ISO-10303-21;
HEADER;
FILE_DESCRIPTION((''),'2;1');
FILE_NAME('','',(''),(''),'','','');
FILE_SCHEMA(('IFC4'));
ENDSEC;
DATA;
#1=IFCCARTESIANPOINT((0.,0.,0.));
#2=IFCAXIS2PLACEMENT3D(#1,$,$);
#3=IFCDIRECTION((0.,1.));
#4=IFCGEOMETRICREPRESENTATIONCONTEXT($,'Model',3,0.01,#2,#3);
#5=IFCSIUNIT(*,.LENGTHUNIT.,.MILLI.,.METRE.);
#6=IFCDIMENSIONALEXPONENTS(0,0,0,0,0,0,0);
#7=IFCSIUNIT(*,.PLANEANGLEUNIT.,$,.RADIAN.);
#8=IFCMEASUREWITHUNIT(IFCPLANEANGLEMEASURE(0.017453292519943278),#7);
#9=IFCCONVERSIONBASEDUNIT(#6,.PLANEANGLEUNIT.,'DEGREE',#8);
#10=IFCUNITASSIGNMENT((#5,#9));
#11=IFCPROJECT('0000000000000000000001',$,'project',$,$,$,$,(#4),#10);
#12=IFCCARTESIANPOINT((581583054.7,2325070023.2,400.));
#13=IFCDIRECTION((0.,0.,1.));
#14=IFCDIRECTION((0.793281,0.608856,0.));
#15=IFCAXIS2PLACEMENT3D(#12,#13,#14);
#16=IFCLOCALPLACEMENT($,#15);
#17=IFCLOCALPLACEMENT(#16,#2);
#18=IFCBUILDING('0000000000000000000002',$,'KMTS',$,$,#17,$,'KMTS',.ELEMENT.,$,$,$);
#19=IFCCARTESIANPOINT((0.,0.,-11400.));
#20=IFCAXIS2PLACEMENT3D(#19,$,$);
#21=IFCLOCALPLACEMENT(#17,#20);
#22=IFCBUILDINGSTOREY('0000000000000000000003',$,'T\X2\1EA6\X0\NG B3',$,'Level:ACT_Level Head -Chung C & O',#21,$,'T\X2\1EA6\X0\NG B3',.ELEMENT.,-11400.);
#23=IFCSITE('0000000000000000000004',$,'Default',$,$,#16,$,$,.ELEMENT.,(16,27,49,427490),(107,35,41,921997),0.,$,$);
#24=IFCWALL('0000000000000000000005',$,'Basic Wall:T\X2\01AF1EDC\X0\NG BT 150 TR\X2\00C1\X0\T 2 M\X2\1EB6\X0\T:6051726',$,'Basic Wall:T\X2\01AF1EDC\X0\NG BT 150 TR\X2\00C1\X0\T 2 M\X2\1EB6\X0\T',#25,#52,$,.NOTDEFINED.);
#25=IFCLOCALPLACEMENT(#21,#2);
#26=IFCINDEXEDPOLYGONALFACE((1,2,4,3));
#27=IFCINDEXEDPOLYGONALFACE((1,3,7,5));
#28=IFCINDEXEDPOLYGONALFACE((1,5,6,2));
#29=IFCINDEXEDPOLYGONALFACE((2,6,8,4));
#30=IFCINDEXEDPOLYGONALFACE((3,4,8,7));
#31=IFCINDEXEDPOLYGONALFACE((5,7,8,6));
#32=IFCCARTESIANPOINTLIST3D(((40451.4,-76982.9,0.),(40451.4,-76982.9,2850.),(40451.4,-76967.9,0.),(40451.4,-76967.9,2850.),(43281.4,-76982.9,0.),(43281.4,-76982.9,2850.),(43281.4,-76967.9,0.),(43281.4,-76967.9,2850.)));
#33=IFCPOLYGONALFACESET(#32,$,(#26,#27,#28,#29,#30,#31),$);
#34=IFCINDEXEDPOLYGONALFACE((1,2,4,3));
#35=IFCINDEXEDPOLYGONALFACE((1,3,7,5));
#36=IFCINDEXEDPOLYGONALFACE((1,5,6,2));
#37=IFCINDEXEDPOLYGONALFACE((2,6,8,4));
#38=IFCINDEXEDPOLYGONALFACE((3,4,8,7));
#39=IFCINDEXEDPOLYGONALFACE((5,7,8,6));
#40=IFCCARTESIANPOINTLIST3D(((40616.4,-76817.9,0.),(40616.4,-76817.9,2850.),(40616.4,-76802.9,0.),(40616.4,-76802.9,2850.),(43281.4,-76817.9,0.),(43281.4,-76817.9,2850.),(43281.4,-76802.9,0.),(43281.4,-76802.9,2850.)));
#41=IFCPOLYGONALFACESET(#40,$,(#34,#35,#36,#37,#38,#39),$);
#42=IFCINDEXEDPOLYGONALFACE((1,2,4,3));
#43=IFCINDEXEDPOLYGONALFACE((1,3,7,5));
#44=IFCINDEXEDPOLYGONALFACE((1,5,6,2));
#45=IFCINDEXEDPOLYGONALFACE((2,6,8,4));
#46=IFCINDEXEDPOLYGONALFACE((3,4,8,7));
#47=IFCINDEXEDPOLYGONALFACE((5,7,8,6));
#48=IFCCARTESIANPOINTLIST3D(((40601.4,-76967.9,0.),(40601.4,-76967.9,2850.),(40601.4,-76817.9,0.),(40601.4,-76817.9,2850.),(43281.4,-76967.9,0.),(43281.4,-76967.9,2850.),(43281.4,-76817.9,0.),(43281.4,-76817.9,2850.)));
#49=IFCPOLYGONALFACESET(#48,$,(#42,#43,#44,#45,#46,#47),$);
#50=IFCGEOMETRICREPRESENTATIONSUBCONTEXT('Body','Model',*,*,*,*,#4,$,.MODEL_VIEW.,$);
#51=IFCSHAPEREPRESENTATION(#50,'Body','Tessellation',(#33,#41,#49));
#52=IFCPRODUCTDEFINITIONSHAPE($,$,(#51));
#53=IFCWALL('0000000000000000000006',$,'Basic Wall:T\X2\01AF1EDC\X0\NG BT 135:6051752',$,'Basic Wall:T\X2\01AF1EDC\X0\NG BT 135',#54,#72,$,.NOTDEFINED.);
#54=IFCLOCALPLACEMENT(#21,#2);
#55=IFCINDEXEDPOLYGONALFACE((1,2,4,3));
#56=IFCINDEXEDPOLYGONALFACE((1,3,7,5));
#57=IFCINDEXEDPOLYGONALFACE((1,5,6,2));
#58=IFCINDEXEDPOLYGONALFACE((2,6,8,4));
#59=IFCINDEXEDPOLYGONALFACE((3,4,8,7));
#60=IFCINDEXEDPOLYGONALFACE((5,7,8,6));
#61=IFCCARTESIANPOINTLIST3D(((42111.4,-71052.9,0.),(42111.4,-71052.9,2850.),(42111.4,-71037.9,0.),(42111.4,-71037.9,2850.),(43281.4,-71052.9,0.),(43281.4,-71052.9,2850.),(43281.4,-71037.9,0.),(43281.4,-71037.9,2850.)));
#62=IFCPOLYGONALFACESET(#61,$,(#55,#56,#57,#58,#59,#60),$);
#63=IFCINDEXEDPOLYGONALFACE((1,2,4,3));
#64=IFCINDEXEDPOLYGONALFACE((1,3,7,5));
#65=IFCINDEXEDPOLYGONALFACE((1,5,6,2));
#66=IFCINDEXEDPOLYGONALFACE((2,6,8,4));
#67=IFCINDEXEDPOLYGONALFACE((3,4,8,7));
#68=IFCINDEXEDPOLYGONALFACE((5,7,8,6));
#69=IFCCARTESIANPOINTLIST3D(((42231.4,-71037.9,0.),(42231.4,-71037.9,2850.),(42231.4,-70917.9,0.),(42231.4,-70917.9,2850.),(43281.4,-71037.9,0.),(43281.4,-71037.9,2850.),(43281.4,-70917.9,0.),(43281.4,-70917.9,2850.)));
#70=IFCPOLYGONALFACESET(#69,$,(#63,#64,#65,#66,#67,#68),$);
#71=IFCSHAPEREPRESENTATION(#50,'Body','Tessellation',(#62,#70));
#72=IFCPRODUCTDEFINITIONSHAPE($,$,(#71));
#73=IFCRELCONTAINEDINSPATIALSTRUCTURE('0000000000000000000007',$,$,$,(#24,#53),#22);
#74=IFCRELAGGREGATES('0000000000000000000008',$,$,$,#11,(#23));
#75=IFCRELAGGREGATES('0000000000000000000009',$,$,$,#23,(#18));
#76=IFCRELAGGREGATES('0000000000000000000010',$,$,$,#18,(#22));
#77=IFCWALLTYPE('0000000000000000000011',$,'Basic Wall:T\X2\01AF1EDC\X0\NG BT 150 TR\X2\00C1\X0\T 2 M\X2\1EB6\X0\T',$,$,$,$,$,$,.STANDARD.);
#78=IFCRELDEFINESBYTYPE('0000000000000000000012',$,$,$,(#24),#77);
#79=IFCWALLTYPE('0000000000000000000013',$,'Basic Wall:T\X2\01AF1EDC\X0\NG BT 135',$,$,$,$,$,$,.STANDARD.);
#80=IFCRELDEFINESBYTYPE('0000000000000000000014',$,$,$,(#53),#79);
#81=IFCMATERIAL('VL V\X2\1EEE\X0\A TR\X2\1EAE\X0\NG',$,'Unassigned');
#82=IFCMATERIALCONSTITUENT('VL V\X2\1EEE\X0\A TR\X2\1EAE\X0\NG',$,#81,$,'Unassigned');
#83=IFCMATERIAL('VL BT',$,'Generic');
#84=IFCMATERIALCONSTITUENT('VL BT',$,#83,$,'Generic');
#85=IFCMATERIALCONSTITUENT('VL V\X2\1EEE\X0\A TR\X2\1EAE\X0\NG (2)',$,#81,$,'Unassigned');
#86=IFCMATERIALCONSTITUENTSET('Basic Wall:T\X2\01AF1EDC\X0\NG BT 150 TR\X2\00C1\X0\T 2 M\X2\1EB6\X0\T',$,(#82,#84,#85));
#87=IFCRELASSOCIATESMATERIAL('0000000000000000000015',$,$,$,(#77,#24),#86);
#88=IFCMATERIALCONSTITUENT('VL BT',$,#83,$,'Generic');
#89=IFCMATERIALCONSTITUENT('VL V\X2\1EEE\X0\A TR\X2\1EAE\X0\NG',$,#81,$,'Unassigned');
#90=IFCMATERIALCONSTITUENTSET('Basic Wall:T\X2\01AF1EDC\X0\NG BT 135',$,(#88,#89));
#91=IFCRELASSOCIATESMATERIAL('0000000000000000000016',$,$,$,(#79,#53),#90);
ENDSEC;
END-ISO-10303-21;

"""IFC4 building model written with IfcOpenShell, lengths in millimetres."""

from ifc_helpers import new_model, entity, si_unit, converted_unit, direction, frame, origin, place, context, subcontext, project, spatial, indexed_curve, outline, extrude, material, constituent, constituent_set, type_object, element, save


model = new_model("IFC4")

# Units and contexts
model_context = context("Model", 3, precision=0.01, world=origin(), true_north=direction((0.0, 1.0)))
body_context = subcontext(model_context, "Body", "Model", "MODEL_VIEW")
ifc_project = project(units=[si_unit("LENGTHUNIT", "METRE", prefix="MILLI"), converted_unit("PLANEANGLEUNIT", "DEGREE", entity("IfcPlaneAngleMeasure", 0.017453292519943278), si_unit("PLANEANGLEUNIT", "RADIAN"), dimensions=[0, 0, 0, 0, 0, 0, 0])], contexts=[model_context])

# Site, building, storey
site_placement = place(None, frame((581583054.7, 2325070023.2, 400.0), z_axis=(0.0, 0.0, 1.0), x_axis=(0.793281, 0.608856, 0.0)))
site = spatial("IfcSite", under=ifc_project, at=site_placement, Name="Default", CompositionType="ELEMENT", RefLatitude=(16, 27, 49, 427490), RefLongitude=(107, 35, 41, 921997), RefElevation=0.0)
building_placement = place(site_placement, origin())
building = spatial("IfcBuilding", under=site, at=building_placement, Name="KMTS", LongName="KMTS", CompositionType="ELEMENT")
storey_placement = place(building_placement, frame((0.0, 0.0, -11400.0)))
storey = spatial("IfcBuildingStorey", under=building, at=storey_placement, Name="TẦNG B3", ObjectType="Level:ACT_Level Head -Chung C & O", LongName="TẦNG B3", CompositionType="ELEMENT", Elevation=-11400.0)

# Shared definitions
ifc_material_1 = material(Name="VL VỮA TRẮNG", Category="Unassigned")
ifc_constituent_1 = constituent(ifc_material_1, Name="VL VỮA TRẮNG", Category="Unassigned")
ifc_material_2 = material(Name="VL BT", Category="Generic")
ifc_constituent_2 = constituent(ifc_material_2, Name="VL BT", Category="Generic")
ifc_constituent_3 = constituent(ifc_material_1, Name="VL VỮA TRẮNG (2)", Category="Unassigned")
ifc_constituent_set_1 = constituent_set(constituents=[ifc_constituent_1, ifc_constituent_2, ifc_constituent_3], Name="Basic Wall:TƯỜNG BT 150 TRÁT 2 MẶT")
wall_type_1 = type_object("IfcWallType", Name="Basic Wall:TƯỜNG BT 150 TRÁT 2 MẶT", PredefinedType="STANDARD", material=ifc_constituent_set_1)

# Walls
wall_1_placement = place(storey_placement, frame((40616.4, -76892.9, 0.0)))
element("IfcWall", 1, at=wall_1_placement, inside=storey, type_object=wall_type_1, material=ifc_constituent_set_1, Name="Basic Wall:TƯỜNG BT 150 TRÁT 2 MẶT:6051726", ObjectType="Basic Wall:TƯỜNG BT 150 TRÁT 2 MẶT", PredefinedType="NOTDEFINED", context=body_context, shape_type="SweptSolid", body=[
    extrude(outline(indexed_curve([(-7.5, -1415.0), (7.5, -1415.0), (7.5, 1415.0), (-7.5, 1415.0), (-7.5, -1415.0)], self_intersect=False)), frame((1250.0, -82.5, 0.0), z_axis=(0.0, 0.0, 1.0), x_axis=(0.0, 1.0, 0.0)), (0.0, 0.0, 1.0), 2850.0),
    extrude(outline(indexed_curve([(-7.5, -1332.5), (7.5, -1332.5), (7.5, 1332.5), (-7.5, 1332.5), (-7.5, -1332.5)], self_intersect=False)), frame((1332.5, 82.5, 0.0), z_axis=(0.0, 0.0, 1.0), x_axis=(0.0, -1.0, 0.0)), (0.0, 0.0, 1.0), 2850.0),
    extrude(outline(indexed_curve([(-1340.0, -75.0), (1340.0, -75.0), (1340.0, 75.0), (-1340.0, 75.0), (-1340.0, -75.0)], self_intersect=False)), frame((1325.0, 0.0, 0.0)), (0.0, 0.0, 1.0), 2850.0),
])
ifc_constituent_4 = constituent(ifc_material_2, Name="VL BT", Category="Generic")
ifc_constituent_5 = constituent(ifc_material_1, Name="VL VỮA TRẮNG", Category="Unassigned")
ifc_constituent_set_2 = constituent_set(constituents=[ifc_constituent_4, ifc_constituent_5], Name="Basic Wall:TƯỜNG BT 135")
wall_type_2 = type_object("IfcWallType", Name="Basic Wall:TƯỜNG BT 135", PredefinedType="STANDARD", material=ifc_constituent_set_2)
wall_2_placement = place(storey_placement, frame((42231.4, -70985.4, 0.0)))
element("IfcWall", 2, at=wall_2_placement, inside=storey, type_object=wall_type_2, material=ifc_constituent_set_2, Name="Basic Wall:TƯỜNG BT 135:6051752", ObjectType="Basic Wall:TƯỜNG BT 135", PredefinedType="NOTDEFINED", context=body_context, shape_type="SweptSolid", body=[
    extrude(outline(indexed_curve([(-7.5, -585.0), (7.5, -585.0), (7.5, 585.0), (-7.5, 585.0), (-7.5, -585.0)], self_intersect=False)), frame((465.0, -60.0, 0.0), z_axis=(0.0, 0.0, 1.0), x_axis=(0.0, 1.0, 0.0)), (0.0, 0.0, 1.0), 2850.0),
    extrude(outline(indexed_curve([(-60.0, -525.0), (60.0, -525.0), (60.0, 525.0), (-60.0, 525.0), (-60.0, -525.0)], self_intersect=False)), frame((525.0, 7.5, 0.0), z_axis=(0.0, 0.0, 1.0), x_axis=(0.0, -1.0, 0.0)), (0.0, 0.0, 1.0), 2850.0),
])

save(model, "model.ifc")
